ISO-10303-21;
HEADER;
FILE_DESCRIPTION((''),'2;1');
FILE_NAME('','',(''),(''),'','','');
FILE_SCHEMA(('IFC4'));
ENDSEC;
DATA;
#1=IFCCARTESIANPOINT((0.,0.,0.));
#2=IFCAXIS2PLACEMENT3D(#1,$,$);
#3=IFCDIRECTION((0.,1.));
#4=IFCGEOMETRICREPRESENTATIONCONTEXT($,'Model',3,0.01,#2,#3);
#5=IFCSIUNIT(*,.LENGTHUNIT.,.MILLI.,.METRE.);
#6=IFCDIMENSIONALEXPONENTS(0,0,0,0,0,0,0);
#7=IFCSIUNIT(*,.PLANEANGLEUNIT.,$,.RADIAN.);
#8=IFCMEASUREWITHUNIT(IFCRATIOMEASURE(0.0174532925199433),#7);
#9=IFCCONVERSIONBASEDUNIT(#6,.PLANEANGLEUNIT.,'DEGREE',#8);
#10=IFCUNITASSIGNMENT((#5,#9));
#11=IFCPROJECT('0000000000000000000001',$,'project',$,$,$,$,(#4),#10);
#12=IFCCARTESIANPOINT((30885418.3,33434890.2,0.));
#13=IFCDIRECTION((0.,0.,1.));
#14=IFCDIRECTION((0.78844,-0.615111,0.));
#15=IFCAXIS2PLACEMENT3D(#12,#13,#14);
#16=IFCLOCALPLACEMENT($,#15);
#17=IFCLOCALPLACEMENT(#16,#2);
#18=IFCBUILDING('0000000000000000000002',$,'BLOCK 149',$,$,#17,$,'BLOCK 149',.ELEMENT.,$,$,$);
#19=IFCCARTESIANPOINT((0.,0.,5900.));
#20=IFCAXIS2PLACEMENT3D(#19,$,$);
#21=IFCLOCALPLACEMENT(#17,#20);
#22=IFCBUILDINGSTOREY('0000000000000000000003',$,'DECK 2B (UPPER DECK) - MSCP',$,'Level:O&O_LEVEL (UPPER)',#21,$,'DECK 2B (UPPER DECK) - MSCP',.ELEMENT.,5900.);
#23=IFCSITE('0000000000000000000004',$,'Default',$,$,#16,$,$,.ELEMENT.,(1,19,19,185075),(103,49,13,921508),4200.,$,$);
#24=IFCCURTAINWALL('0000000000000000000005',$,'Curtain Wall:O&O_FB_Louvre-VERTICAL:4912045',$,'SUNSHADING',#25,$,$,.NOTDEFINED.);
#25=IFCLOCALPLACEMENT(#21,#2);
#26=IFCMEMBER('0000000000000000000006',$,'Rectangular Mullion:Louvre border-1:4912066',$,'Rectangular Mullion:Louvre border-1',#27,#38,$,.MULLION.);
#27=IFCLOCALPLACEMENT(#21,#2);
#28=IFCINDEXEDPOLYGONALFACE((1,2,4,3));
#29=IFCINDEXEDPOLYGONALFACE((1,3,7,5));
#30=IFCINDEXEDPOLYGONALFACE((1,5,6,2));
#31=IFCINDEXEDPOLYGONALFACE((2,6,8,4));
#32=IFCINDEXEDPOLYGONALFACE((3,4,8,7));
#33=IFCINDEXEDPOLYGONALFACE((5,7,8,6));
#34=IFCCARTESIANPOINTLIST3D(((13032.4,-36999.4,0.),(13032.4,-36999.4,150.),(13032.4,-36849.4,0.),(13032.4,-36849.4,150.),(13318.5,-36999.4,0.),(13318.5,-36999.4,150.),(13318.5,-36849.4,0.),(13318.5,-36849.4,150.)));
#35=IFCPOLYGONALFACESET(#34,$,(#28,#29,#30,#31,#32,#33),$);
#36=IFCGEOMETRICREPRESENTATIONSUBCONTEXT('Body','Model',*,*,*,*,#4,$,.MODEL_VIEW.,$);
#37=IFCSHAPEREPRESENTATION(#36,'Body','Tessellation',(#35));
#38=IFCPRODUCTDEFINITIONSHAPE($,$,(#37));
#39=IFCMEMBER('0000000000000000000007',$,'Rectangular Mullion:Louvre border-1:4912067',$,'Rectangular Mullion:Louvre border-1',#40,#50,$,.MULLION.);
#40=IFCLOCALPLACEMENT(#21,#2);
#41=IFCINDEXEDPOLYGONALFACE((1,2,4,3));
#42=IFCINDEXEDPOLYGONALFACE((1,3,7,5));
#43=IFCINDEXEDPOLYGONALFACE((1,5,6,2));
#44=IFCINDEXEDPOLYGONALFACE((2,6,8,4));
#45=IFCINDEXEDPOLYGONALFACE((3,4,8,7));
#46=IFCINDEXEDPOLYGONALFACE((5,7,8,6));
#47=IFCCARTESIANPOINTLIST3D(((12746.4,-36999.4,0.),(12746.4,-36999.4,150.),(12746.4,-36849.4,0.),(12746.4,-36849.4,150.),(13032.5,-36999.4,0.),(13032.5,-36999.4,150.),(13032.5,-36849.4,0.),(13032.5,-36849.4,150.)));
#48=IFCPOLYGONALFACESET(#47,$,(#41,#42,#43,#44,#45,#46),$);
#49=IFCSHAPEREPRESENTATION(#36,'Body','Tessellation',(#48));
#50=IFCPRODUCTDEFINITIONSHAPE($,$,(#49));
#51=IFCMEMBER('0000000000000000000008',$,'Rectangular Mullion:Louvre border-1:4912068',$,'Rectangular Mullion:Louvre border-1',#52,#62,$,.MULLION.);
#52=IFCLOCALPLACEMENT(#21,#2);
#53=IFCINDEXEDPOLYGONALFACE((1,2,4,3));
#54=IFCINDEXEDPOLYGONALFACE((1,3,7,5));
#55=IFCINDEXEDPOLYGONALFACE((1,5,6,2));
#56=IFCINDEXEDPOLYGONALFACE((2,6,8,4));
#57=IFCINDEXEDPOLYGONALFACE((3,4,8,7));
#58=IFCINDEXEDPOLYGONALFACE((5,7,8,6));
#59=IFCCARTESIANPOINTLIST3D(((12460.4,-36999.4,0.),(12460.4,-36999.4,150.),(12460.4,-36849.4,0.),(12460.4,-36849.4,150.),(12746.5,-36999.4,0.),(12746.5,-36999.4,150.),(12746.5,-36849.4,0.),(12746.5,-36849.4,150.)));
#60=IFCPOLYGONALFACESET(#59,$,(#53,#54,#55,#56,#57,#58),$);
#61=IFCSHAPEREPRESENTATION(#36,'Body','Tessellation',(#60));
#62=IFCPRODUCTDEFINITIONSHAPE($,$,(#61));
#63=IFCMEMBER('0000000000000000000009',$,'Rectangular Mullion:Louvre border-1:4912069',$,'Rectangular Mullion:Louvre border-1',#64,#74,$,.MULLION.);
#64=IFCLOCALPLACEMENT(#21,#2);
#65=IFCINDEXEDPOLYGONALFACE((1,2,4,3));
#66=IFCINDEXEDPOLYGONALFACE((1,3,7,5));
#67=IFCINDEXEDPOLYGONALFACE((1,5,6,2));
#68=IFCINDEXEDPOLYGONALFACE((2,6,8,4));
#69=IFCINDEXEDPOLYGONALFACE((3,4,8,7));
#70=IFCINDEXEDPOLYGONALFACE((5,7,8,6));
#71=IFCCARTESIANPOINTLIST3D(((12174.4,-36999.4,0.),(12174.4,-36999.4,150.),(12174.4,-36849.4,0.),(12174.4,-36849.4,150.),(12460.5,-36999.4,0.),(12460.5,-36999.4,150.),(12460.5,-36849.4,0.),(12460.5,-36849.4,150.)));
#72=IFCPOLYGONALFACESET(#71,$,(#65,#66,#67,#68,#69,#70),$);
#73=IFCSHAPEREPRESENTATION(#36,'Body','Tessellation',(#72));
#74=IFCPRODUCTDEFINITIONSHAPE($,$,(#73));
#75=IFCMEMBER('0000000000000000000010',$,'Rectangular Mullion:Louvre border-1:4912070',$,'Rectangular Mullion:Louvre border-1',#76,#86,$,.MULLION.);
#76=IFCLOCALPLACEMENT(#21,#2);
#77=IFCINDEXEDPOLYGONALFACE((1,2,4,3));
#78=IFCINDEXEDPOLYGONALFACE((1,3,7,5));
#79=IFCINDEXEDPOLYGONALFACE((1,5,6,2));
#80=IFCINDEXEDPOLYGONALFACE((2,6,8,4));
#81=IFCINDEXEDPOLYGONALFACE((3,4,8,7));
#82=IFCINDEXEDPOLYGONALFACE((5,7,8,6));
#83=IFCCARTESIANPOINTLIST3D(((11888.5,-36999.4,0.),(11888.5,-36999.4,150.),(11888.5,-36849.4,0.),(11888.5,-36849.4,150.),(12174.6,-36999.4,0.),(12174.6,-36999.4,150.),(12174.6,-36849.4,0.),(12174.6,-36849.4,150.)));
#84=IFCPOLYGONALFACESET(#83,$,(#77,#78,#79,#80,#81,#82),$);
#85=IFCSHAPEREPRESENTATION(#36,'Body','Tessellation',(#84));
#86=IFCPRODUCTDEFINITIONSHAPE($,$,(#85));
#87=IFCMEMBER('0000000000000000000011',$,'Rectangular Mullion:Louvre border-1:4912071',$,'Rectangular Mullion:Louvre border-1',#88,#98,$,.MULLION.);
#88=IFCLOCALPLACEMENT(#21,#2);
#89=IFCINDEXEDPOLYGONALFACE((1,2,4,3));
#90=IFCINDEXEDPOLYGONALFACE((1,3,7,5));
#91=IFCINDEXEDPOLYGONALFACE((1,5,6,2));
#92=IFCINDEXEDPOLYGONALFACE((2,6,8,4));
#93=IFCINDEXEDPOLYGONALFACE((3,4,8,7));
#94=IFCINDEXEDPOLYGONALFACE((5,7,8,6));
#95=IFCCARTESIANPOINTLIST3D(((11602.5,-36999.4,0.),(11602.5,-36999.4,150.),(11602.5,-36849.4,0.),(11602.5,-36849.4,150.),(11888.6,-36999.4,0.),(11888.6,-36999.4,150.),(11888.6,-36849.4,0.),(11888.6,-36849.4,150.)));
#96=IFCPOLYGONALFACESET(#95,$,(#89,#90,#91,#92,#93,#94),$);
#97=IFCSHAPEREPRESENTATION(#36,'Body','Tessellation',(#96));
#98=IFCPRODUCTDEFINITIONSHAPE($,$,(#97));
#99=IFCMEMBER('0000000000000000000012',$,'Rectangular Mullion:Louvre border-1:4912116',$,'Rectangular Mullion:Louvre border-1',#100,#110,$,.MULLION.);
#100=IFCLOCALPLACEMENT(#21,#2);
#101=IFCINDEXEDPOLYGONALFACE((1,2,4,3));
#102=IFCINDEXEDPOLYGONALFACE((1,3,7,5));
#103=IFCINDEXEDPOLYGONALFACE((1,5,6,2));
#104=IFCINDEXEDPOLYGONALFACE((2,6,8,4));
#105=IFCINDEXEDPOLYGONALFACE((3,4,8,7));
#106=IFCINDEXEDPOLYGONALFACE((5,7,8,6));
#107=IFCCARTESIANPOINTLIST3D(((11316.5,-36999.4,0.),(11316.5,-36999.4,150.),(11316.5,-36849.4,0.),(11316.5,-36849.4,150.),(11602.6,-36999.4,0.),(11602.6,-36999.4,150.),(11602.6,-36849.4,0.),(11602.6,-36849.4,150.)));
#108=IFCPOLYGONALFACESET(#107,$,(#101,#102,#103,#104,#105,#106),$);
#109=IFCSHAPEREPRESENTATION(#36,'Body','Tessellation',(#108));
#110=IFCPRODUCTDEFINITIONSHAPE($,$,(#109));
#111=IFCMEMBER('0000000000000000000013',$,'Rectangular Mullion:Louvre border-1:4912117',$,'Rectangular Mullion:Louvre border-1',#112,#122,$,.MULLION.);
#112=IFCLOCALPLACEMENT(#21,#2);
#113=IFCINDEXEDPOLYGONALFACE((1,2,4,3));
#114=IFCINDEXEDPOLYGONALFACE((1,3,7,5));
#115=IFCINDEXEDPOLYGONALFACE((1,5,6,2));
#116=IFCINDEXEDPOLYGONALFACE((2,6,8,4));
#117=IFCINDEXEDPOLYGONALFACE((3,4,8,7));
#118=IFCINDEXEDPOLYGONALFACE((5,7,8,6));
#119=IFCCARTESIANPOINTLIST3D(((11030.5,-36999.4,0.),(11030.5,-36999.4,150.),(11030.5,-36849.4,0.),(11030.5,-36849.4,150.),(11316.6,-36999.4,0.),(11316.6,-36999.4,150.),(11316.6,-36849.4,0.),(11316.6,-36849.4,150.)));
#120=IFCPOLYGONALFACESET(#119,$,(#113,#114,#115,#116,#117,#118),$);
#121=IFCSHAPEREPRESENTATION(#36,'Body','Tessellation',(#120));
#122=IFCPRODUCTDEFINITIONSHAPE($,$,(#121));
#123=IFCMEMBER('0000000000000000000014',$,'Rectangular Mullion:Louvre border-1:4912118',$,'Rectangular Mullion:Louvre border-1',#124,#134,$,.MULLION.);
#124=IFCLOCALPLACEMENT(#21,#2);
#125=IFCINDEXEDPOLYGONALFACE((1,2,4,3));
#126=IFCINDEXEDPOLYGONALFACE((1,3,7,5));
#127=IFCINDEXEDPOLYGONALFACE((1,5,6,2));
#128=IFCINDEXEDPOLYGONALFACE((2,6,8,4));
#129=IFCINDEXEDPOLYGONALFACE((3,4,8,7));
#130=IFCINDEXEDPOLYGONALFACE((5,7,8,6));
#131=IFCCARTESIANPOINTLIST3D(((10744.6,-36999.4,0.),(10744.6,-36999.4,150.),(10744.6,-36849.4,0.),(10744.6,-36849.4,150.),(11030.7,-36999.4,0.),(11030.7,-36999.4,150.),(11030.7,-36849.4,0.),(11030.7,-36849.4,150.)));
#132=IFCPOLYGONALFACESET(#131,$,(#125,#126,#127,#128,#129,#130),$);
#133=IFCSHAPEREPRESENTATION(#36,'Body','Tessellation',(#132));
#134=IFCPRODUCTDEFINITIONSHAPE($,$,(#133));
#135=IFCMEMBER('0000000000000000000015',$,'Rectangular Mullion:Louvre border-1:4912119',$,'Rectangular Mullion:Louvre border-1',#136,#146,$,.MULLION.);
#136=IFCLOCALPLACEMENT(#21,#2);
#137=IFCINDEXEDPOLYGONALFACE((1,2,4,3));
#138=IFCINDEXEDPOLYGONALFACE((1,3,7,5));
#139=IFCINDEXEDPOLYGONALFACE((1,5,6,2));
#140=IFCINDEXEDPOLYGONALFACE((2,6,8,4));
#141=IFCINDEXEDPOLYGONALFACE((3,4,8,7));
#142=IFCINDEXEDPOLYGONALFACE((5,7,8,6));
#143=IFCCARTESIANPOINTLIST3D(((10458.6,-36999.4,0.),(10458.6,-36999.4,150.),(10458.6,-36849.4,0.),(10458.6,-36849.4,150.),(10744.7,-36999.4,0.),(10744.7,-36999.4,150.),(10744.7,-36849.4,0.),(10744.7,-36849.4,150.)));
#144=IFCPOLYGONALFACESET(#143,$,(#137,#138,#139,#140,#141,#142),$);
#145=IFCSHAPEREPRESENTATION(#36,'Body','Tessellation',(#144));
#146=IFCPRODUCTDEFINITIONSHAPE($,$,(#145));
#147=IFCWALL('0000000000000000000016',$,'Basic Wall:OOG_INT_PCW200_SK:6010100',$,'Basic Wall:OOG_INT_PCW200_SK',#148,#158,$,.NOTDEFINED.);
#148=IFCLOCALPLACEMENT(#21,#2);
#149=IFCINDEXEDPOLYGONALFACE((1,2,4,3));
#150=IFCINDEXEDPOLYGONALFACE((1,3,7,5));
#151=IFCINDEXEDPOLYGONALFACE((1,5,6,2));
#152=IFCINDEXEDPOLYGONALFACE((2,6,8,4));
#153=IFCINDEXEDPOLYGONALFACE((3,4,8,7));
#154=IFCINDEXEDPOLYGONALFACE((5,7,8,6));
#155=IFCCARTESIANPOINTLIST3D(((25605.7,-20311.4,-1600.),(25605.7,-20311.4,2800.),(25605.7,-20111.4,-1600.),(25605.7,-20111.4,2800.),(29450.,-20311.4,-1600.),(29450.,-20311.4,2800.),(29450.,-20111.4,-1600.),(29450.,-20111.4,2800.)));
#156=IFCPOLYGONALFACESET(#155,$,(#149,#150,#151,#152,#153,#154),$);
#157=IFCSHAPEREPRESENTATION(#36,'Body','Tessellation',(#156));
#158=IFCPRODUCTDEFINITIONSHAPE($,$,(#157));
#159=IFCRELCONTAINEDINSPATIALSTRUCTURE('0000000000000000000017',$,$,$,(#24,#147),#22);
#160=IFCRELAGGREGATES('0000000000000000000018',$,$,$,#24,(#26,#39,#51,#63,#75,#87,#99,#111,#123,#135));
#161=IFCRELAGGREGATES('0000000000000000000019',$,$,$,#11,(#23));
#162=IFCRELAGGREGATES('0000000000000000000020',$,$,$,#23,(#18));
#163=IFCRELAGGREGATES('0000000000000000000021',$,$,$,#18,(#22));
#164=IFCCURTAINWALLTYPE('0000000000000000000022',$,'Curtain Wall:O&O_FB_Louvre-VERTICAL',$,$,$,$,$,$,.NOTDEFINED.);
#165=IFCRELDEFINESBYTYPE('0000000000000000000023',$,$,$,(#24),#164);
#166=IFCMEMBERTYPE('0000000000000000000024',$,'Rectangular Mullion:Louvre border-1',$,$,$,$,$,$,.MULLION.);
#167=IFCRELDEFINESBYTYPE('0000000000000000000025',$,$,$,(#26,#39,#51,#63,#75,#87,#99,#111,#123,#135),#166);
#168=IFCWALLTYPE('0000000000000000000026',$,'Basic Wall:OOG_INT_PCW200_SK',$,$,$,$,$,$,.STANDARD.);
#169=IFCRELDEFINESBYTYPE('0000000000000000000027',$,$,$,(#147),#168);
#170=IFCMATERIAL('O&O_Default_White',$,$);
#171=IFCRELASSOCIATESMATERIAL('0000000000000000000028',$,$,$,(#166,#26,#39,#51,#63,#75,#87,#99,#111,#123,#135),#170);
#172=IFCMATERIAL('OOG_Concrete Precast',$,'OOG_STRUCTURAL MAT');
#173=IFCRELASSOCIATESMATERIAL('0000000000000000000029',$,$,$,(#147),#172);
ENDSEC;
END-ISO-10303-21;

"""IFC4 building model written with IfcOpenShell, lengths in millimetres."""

from ifc_helpers import new_model, entity, si_unit, converted_unit, direction, frame, origin, place, context, subcontext, project, spatial, indexed_curve, outline, extrude, source, transform, mapped, material, type_object, type_shapes, element, aggregate, save


model = new_model("IFC4")

# Units and contexts
model_context = context("Model", 3, precision=0.01, world=origin(), true_north=direction((0.0, 1.0)))
body_context = subcontext(model_context, "Body", "Model", "MODEL_VIEW")
ifc_project = project(units=[si_unit("LENGTHUNIT", "METRE", prefix="MILLI"), converted_unit("PLANEANGLEUNIT", "DEGREE", entity("IfcRatioMeasure", 0.0174532925199433), si_unit("PLANEANGLEUNIT", "RADIAN"), dimensions=[0, 0, 0, 0, 0, 0, 0])], contexts=[model_context])

# Site, building, storey
site_placement = place(None, frame((30885418.3, 33434890.2, 0.0), z_axis=(0.0, 0.0, 1.0), x_axis=(0.78844, -0.615111, 0.0)))
site = spatial("IfcSite", under=ifc_project, at=site_placement, Name="Default", CompositionType="ELEMENT", RefLatitude=(1, 19, 19, 185075), RefLongitude=(103, 49, 13, 921508), RefElevation=4200.0)
building_placement = place(site_placement, origin())
building = spatial("IfcBuilding", under=site, at=building_placement, Name="BLOCK 149", LongName="BLOCK 149", CompositionType="ELEMENT")
storey_placement = place(building_placement, frame((0.0, 0.0, 5900.0)))
storey = spatial("IfcBuildingStorey", under=building, at=storey_placement, Name="DECK 2B (UPPER DECK) - MSCP", ObjectType="Level:O&O_LEVEL (UPPER)", LongName="DECK 2B (UPPER DECK) - MSCP", CompositionType="ELEMENT", Elevation=5900.0)

# Curtain wall, members
curtain_wall_type = type_object("IfcCurtainWallType", Name="Curtain Wall:O&O_FB_Louvre-VERTICAL", PredefinedType="NOTDEFINED")
curtain_wall_placement = place(storey_placement, frame((0.0, 0.0, -5900.0)))
curtain_wall = element("IfcCurtainWall", 1, at=curtain_wall_placement, inside=storey, type_object=curtain_wall_type, Name="Curtain Wall:O&O_FB_Louvre-VERTICAL:4912045", ObjectType="SUNSHADING", PredefinedType="NOTDEFINED")
ifc_material_1 = material(Name="O&O_Default_White")
placement = place(building_placement, origin())
member_type_1 = type_object("IfcMemberType", Name="Rectangular Mullion:Louvre border-1", PredefinedType="MULLION", material=ifc_material_1)
shared_shape_1 = source(origin(), body_context, "Body", "SweptSolid", [
    extrude(outline(indexed_curve([(-75.0, -75.0), (75.0, -75.0), (75.0, 75.0), (-75.0, 75.0), (-75.0, -75.0)], self_intersect=False)), frame((-75.0, 0.0, -286.1), z_axis=(0.0, 0.0, 1.0), x_axis=(0.0, -1.0, 0.0)), (0.0, 0.0, 1.0), 286.1),
])
type_shapes(member_type_1, [shared_shape_1])
member_1_placement = place(placement, frame((13318.5, -36924.4, 5900.0), z_axis=(1.0, 0.0, 0.0), x_axis=(0.0, 0.0, -1.0)))
member_1 = element("IfcMember", 2, at=member_1_placement, type_object=member_type_1, material=ifc_material_1, Name="Rectangular Mullion:Louvre border-1:4912066", ObjectType="Rectangular Mullion:Louvre border-1", PredefinedType="MULLION", context=body_context, shape_type="MappedRepresentation", body=[
    mapped(shared_shape_1, transform((0.0, 0.0, 0.0), scale=1.0)),
])
member_2_placement = place(placement, frame((13032.5, -36924.4, 5900.0), z_axis=(1.0, 0.0, 0.0), x_axis=(0.0, 0.0, -1.0)))
member_2 = element("IfcMember", 3, at=member_2_placement, type_object=member_type_1, material=ifc_material_1, Name="Rectangular Mullion:Louvre border-1:4912067", ObjectType="Rectangular Mullion:Louvre border-1", PredefinedType="MULLION", context=body_context, shape_type="MappedRepresentation", body=[
    mapped(shared_shape_1, transform((0.0, 0.0, 0.0), scale=1.0)),
])
member_3_placement = place(placement, frame((12746.5, -36924.4, 5900.0), z_axis=(1.0, 0.0, 0.0), x_axis=(0.0, 0.0, -1.0)))
member_3 = element("IfcMember", 4, at=member_3_placement, type_object=member_type_1, material=ifc_material_1, Name="Rectangular Mullion:Louvre border-1:4912068", ObjectType="Rectangular Mullion:Louvre border-1", PredefinedType="MULLION", context=body_context, shape_type="MappedRepresentation", body=[
    mapped(shared_shape_1, transform((0.0, 0.0, 0.0), scale=1.0)),
])
member_4_placement = place(placement, frame((12460.5, -36924.4, 5900.0), z_axis=(1.0, 0.0, 0.0), x_axis=(0.0, 0.0, -1.0)))
member_4 = element("IfcMember", 5, at=member_4_placement, type_object=member_type_1, material=ifc_material_1, Name="Rectangular Mullion:Louvre border-1:4912069", ObjectType="Rectangular Mullion:Louvre border-1", PredefinedType="MULLION", context=body_context, shape_type="MappedRepresentation", body=[
    mapped(shared_shape_1, transform((0.0, 0.0, 0.0), scale=1.0)),
])
member_5_placement = place(placement, frame((12174.6, -36924.4, 5900.0), z_axis=(1.0, 0.0, 0.0), x_axis=(0.0, 0.0, -1.0)))
member_5 = element("IfcMember", 6, at=member_5_placement, type_object=member_type_1, material=ifc_material_1, Name="Rectangular Mullion:Louvre border-1:4912070", ObjectType="Rectangular Mullion:Louvre border-1", PredefinedType="MULLION", context=body_context, shape_type="MappedRepresentation", body=[
    mapped(shared_shape_1, transform((0.0, 0.0, 0.0), scale=1.0)),
])
member_6_placement = place(placement, frame((11888.6, -36924.4, 5900.0), z_axis=(1.0, 0.0, 0.0), x_axis=(0.0, 0.0, -1.0)))
member_6 = element("IfcMember", 7, at=member_6_placement, type_object=member_type_1, material=ifc_material_1, Name="Rectangular Mullion:Louvre border-1:4912071", ObjectType="Rectangular Mullion:Louvre border-1", PredefinedType="MULLION", context=body_context, shape_type="MappedRepresentation", body=[
    mapped(shared_shape_1, transform((0.0, 0.0, 0.0), scale=1.0)),
])
member_7_placement = place(placement, frame((11602.6, -36924.4, 5900.0), z_axis=(1.0, 0.0, 0.0), x_axis=(0.0, 0.0, -1.0)))
member_7 = element("IfcMember", 8, at=member_7_placement, type_object=member_type_1, material=ifc_material_1, Name="Rectangular Mullion:Louvre border-1:4912116", ObjectType="Rectangular Mullion:Louvre border-1", PredefinedType="MULLION", context=body_context, shape_type="MappedRepresentation", body=[
    mapped(shared_shape_1, transform((0.0, 0.0, 0.0), scale=1.0)),
])
member_8_placement = place(placement, frame((11316.6, -36924.4, 5900.0), z_axis=(1.0, 0.0, 0.0), x_axis=(0.0, 0.0, -1.0)))
member_8 = element("IfcMember", 9, at=member_8_placement, type_object=member_type_1, material=ifc_material_1, Name="Rectangular Mullion:Louvre border-1:4912117", ObjectType="Rectangular Mullion:Louvre border-1", PredefinedType="MULLION", context=body_context, shape_type="MappedRepresentation", body=[
    mapped(shared_shape_1, transform((0.0, 0.0, 0.0), scale=1.0)),
])
member_9_placement = place(placement, frame((11030.7, -36924.4, 5900.0), z_axis=(1.0, 0.0, 0.0), x_axis=(0.0, 0.0, -1.0)))
member_9 = element("IfcMember", 10, at=member_9_placement, type_object=member_type_1, material=ifc_material_1, Name="Rectangular Mullion:Louvre border-1:4912118", ObjectType="Rectangular Mullion:Louvre border-1", PredefinedType="MULLION", context=body_context, shape_type="MappedRepresentation", body=[
    mapped(shared_shape_1, transform((0.0, 0.0, 0.0), scale=1.0)),
])
member_10_placement = place(placement, frame((10744.7, -36924.4, 5900.0), z_axis=(1.0, 0.0, 0.0), x_axis=(0.0, 0.0, -1.0)))
member_10 = element("IfcMember", 11, at=member_10_placement, type_object=member_type_1, material=ifc_material_1, Name="Rectangular Mullion:Louvre border-1:4912119", ObjectType="Rectangular Mullion:Louvre border-1", PredefinedType="MULLION", context=body_context, shape_type="MappedRepresentation", body=[
    mapped(shared_shape_1, transform((0.0, 0.0, 0.0), scale=1.0)),
])
aggregate(curtain_wall, [member_1, member_2, member_3, member_4, member_5, member_6, member_7, member_8, member_9, member_10])

# Wall
ifc_material_2 = material(Name="OOG_Concrete Precast", Category="OOG_STRUCTURAL MAT")
wall_type = type_object("IfcWallType", Name="Basic Wall:OOG_INT_PCW200_SK", PredefinedType="STANDARD")
wall_placement = place(storey_placement, frame((29450.0, -20211.4, -1600.0), z_axis=(0.0, 0.0, 1.0), x_axis=(-1.0, 0.0, 0.0)))
element("IfcWall", 12, at=wall_placement, inside=storey, type_object=wall_type, material=ifc_material_2, Name="Basic Wall:OOG_INT_PCW200_SK:6010100", ObjectType="Basic Wall:OOG_INT_PCW200_SK", PredefinedType="NOTDEFINED", context=body_context, shape_type="SweptSolid", body=[
    extrude(outline(indexed_curve([(3844.2, 100.0), (0.0, 100.0), (0.0, -100.0), (3844.2, -100.0), (3844.2, 100.0)], self_intersect=False)), origin(), (0.0, 0.0, 1.0), 4400.0),
])

save(model, "model.ifc")
